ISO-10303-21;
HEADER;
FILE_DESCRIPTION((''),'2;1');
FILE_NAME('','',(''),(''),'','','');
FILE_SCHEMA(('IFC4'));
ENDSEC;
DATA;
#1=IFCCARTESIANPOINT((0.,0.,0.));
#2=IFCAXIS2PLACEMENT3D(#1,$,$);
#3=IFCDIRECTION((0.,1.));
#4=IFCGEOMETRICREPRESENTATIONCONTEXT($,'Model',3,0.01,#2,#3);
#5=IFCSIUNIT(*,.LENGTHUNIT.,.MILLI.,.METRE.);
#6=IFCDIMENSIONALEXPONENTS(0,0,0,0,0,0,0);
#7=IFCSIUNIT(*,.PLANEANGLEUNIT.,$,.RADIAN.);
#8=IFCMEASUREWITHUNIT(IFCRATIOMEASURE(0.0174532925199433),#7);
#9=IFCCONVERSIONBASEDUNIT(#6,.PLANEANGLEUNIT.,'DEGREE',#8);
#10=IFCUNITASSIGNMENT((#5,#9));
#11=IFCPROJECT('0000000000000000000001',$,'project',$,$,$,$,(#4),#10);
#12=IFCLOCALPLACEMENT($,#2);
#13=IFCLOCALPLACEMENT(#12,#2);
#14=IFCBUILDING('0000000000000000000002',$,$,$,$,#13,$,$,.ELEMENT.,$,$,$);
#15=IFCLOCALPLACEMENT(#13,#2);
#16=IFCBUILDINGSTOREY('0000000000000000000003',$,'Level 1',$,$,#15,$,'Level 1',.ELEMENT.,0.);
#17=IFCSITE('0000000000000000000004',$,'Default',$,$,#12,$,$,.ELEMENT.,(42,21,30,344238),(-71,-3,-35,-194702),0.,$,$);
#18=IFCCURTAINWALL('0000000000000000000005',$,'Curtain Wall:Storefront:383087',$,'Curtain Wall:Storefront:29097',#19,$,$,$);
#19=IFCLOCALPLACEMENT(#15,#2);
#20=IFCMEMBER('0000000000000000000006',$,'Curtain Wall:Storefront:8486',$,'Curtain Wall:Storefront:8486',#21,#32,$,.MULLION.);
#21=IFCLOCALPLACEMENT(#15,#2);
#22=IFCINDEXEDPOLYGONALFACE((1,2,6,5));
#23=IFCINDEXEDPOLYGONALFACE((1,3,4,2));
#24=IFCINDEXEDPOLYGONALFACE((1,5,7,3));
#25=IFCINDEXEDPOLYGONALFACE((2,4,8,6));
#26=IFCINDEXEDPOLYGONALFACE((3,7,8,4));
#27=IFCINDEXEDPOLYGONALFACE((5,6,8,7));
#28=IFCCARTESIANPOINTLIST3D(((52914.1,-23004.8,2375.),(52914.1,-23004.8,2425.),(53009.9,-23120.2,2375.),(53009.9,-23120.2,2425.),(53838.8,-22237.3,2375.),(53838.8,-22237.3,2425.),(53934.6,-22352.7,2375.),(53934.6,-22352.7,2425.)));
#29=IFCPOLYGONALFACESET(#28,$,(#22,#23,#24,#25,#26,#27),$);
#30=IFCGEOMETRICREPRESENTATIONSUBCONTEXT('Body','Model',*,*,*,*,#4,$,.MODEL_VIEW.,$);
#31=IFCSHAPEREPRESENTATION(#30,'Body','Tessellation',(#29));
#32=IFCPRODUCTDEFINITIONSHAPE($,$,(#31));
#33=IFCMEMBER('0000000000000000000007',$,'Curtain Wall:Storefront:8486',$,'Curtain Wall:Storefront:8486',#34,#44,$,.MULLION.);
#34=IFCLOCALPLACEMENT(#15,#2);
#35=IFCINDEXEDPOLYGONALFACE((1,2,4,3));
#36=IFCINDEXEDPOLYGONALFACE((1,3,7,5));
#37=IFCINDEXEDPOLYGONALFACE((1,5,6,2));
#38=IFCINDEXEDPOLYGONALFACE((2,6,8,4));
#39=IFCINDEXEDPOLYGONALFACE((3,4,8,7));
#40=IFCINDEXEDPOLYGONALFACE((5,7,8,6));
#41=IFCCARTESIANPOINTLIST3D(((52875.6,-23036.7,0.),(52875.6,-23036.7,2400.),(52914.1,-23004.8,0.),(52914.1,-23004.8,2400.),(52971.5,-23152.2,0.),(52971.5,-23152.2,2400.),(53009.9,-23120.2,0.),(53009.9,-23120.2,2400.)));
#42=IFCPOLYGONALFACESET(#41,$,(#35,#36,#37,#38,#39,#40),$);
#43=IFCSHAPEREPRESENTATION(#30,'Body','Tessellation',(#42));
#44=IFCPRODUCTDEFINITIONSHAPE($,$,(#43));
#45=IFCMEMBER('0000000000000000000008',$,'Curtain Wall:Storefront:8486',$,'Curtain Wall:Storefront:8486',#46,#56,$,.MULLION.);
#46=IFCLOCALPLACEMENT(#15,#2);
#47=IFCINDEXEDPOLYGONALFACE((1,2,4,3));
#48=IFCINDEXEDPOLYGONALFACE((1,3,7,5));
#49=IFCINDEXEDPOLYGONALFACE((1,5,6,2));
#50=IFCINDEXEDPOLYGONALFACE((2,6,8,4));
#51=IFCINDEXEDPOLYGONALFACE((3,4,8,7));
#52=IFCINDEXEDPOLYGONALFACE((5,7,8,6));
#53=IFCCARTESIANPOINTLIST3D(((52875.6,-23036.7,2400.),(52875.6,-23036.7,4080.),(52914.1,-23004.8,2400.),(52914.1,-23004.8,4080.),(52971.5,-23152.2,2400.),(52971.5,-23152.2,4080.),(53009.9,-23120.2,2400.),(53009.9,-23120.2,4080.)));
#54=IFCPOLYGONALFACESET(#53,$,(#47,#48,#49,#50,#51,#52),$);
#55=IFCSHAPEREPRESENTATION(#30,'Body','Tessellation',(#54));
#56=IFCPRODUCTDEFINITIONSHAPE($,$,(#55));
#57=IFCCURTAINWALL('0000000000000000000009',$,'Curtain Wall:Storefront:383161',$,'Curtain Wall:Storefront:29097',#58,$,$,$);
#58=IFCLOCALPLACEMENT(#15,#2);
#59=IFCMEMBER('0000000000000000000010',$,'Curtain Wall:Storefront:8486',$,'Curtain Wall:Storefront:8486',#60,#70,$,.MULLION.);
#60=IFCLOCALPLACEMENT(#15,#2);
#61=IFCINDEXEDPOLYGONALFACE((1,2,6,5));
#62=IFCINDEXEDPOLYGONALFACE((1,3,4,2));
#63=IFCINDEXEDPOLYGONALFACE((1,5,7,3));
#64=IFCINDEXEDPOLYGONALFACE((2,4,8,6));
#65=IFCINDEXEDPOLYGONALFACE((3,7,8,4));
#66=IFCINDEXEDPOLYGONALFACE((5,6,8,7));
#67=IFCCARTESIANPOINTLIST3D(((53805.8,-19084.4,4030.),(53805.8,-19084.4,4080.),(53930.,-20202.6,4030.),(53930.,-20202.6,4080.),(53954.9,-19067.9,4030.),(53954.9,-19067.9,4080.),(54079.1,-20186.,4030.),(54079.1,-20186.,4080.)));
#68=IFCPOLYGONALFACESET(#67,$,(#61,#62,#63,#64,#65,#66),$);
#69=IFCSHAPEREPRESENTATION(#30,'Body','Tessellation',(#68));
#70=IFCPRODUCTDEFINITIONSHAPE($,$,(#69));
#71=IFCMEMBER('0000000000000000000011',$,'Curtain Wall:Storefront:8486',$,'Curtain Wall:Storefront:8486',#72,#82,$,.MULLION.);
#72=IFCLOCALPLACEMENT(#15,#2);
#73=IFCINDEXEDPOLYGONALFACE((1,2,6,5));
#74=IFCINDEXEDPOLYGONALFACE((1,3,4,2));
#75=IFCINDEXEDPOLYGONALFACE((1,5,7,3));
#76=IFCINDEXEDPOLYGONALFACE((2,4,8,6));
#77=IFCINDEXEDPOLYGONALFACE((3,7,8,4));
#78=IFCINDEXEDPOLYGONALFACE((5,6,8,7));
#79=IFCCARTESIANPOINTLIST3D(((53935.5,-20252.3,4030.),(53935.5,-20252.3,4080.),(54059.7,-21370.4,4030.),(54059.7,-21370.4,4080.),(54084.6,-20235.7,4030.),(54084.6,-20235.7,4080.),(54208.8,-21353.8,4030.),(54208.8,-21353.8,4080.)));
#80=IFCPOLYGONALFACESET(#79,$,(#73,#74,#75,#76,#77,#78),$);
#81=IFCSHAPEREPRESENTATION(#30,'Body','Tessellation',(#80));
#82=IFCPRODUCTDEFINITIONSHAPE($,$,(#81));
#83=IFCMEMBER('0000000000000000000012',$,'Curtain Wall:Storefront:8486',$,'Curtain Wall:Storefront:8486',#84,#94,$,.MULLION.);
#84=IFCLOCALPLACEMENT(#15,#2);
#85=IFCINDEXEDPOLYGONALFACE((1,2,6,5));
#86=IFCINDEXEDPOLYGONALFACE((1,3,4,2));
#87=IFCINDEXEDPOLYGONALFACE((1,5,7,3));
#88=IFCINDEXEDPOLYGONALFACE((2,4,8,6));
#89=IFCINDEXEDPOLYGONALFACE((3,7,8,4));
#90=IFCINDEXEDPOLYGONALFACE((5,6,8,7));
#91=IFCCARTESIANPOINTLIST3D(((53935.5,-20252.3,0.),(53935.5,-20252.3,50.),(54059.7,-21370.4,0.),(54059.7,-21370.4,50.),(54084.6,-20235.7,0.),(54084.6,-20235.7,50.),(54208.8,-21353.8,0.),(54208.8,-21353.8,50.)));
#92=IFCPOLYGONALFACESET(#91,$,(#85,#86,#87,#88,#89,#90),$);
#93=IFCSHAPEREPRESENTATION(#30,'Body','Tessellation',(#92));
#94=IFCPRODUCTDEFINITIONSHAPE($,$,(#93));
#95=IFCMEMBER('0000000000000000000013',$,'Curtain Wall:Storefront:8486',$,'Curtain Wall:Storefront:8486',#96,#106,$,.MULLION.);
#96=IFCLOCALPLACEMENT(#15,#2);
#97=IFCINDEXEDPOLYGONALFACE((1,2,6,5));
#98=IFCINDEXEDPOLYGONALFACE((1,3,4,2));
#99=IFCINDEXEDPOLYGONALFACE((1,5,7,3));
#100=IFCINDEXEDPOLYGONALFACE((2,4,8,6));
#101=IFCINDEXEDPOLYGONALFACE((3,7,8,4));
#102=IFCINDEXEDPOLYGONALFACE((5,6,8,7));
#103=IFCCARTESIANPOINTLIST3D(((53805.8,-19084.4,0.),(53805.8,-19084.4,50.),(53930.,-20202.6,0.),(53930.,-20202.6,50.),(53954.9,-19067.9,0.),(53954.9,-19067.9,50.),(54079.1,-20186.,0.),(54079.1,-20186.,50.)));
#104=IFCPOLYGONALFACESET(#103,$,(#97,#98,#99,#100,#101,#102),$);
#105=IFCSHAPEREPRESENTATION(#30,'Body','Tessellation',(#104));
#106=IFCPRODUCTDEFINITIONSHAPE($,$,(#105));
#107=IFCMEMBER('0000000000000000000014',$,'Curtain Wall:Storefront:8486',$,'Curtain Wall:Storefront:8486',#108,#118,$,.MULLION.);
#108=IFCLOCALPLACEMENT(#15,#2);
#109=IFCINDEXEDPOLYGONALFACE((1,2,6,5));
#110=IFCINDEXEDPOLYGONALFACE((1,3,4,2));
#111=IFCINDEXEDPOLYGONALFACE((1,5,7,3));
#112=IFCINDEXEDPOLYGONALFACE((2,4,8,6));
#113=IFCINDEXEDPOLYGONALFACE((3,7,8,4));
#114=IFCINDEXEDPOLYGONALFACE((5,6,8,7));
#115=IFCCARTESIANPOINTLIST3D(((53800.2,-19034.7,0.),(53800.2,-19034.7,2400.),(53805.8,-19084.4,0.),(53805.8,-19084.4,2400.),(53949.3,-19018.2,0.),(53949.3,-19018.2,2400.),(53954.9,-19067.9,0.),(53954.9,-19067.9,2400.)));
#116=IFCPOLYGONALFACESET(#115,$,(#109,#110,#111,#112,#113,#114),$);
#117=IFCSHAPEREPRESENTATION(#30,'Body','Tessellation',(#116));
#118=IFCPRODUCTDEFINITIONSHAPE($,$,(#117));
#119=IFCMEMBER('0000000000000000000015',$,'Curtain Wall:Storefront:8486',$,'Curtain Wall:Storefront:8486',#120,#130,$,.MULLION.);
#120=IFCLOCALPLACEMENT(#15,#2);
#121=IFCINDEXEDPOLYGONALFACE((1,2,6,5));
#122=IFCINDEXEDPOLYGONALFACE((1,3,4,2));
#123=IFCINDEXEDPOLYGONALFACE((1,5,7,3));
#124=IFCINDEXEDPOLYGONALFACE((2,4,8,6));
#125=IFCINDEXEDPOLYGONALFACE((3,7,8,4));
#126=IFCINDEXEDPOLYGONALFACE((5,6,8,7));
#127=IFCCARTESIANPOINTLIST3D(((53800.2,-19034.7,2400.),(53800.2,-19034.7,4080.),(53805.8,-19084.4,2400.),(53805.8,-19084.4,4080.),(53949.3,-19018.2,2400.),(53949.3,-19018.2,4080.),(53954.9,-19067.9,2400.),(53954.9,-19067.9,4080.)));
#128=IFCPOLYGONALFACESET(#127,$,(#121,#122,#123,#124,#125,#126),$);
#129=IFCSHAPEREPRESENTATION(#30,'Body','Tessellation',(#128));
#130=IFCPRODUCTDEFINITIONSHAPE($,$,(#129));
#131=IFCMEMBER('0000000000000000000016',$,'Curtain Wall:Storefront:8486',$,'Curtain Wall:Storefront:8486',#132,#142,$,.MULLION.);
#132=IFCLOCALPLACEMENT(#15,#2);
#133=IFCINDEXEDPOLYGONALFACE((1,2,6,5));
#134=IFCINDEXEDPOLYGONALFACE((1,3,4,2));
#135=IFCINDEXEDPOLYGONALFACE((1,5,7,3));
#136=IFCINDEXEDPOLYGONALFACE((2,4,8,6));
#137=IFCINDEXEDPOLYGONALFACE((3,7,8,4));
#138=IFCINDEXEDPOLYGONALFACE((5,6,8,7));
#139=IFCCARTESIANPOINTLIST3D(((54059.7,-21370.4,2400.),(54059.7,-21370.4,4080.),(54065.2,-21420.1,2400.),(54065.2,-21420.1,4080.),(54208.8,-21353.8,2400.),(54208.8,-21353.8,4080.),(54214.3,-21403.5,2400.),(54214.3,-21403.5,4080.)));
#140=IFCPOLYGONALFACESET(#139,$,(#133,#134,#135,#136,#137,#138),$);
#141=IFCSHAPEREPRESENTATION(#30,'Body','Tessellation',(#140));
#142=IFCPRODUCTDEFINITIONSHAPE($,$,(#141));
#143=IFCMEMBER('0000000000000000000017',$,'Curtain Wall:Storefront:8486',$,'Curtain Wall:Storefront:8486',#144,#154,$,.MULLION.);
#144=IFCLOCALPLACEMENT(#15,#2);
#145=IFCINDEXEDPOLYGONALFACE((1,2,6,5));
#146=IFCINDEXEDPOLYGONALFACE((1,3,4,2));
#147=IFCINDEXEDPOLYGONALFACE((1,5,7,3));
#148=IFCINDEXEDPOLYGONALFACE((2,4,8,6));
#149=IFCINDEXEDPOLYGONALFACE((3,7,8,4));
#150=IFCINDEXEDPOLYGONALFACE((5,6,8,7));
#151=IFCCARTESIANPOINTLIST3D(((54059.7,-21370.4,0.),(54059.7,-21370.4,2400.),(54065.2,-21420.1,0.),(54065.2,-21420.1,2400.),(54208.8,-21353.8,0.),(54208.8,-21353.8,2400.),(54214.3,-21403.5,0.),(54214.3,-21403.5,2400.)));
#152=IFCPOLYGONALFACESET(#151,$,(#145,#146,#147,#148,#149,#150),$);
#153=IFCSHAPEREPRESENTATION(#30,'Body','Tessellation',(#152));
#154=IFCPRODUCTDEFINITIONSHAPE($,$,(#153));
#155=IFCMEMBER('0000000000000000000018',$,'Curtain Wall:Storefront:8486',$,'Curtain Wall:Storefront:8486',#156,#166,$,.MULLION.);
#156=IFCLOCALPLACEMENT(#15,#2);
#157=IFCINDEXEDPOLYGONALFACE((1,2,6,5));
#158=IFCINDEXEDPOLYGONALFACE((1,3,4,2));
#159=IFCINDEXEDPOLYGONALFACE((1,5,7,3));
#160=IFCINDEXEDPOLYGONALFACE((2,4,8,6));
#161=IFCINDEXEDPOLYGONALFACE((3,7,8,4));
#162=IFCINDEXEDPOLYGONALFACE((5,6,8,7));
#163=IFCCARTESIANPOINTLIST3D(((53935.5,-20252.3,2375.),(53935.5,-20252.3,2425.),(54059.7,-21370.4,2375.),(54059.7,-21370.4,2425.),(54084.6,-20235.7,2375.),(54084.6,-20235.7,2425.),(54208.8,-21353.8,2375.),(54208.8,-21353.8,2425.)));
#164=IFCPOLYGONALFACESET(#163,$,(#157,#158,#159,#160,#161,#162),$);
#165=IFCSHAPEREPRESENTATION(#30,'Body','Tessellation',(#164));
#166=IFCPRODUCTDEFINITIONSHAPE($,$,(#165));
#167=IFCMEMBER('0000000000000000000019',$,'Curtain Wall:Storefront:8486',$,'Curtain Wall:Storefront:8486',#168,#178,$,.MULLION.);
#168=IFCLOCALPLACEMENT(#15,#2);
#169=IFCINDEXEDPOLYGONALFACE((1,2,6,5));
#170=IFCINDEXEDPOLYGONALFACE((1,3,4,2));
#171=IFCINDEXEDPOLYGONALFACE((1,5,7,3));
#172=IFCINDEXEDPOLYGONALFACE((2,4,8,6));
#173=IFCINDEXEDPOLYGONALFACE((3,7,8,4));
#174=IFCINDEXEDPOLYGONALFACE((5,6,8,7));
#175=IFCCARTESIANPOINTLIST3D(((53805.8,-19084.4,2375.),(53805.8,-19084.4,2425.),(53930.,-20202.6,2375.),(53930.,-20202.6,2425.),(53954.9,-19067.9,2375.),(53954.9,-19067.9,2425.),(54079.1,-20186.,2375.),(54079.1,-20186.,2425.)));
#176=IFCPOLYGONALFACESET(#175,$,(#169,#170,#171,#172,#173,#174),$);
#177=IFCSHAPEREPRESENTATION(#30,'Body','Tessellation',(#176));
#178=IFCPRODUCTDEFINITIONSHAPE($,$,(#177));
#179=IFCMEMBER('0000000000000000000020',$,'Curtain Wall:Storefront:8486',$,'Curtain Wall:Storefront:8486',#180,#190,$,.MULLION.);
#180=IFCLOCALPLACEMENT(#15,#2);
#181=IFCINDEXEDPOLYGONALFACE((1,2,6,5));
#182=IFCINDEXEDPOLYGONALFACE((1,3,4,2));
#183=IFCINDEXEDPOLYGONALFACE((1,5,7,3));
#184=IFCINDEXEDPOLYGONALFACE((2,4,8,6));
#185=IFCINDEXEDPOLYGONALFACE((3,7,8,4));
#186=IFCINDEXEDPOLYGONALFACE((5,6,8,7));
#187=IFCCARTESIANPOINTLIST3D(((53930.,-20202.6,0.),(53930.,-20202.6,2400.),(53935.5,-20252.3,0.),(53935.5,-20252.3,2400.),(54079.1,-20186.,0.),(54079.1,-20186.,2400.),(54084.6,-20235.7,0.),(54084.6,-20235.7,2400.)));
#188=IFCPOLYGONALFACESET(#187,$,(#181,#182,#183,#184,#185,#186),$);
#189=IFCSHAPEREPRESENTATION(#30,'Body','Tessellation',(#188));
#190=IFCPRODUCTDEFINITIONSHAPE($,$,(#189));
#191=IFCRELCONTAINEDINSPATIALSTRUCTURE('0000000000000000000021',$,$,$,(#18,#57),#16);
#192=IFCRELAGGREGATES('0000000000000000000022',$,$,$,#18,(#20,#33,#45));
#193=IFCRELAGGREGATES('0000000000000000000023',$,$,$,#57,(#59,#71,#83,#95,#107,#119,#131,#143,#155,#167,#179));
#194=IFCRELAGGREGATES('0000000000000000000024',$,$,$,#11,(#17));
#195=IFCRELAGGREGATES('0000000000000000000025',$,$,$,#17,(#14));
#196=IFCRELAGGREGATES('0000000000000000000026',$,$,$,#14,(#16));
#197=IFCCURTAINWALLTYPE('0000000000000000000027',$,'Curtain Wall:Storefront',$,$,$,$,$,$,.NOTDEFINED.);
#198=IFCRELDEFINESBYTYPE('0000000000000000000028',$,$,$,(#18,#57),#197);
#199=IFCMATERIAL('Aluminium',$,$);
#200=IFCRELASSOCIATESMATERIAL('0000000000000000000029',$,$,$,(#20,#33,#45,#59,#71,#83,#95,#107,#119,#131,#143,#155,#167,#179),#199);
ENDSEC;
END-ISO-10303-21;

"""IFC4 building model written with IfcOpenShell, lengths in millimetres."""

from ifc_helpers import new_model, entity, si_unit, converted_unit, direction, frame, frame_2d, origin, origin_2d_with_axis, place, context, subcontext, project, spatial, rectangle, extrude, material, type_object, element, aggregate, save


model = new_model("IFC4")

# Units and contexts
model_context = context("Model", 3, precision=0.01, world=origin(), true_north=direction((0.0, 1.0)))
body_context = subcontext(model_context, "Body", "Model", "MODEL_VIEW")
ifc_project = project(units=[si_unit("LENGTHUNIT", "METRE", prefix="MILLI"), converted_unit("PLANEANGLEUNIT", "DEGREE", entity("IfcRatioMeasure", 0.0174532925199433), si_unit("PLANEANGLEUNIT", "RADIAN"), dimensions=[0, 0, 0, 0, 0, 0, 0])], contexts=[model_context])

# Site, building, storey
site_placement = place(None, origin())
site = spatial("IfcSite", under=ifc_project, at=site_placement, Name="Default", CompositionType="ELEMENT", RefLatitude=(42, 21, 30, 344238), RefLongitude=(-71, -3, -35, -194702), RefElevation=0.0)
building_placement = place(site_placement, origin())
building = spatial("IfcBuilding", under=site, at=building_placement, CompositionType="ELEMENT")
storey_placement = place(building_placement, origin())
storey = spatial("IfcBuildingStorey", under=building, at=storey_placement, Name="Level 1", LongName="Level 1", CompositionType="ELEMENT", Elevation=0.0)

# Curtain walls, members
curtain_wall_type = type_object("IfcCurtainWallType", Name="Curtain Wall:Storefront", PredefinedType="NOTDEFINED")
curtain_wall_1_placement = place(storey_placement, origin())
curtain_wall_1 = element("IfcCurtainWall", 1, at=curtain_wall_1_placement, inside=storey, type_object=curtain_wall_type, Name="Curtain Wall:Storefront:383087", ObjectType="Curtain Wall:Storefront:29097")
ifc_material = material(Name="Aluminium")
member_1_placement = place(curtain_wall_1_placement, origin())
member_1 = element("IfcMember", 2, at=member_1_placement, material=ifc_material, Name="Curtain Wall:Storefront:8486", ObjectType="Curtain Wall:Storefront:8486", PredefinedType="MULLION", context=body_context, shape_type="SweptSolid", body=[
    extrude(rectangle(XDim=50.0, YDim=150.0, at=origin_2d_with_axis()), frame((53886.7, -22295.0, 2400.0), z_axis=(-0.769477, -0.638675, 0.0), x_axis=(0.0, 0.0, -1.0)), (0.0, 0.0, 1.0), 1201.7),
])
member_2_placement = place(curtain_wall_1_placement, origin())
member_2 = element("IfcMember", 3, at=member_2_placement, material=ifc_material, Name="Curtain Wall:Storefront:8486", ObjectType="Curtain Wall:Storefront:8486", PredefinedType="MULLION", context=body_context, shape_type="SweptSolid", body=[
    extrude(rectangle(XDim=50.0, YDim=150.0, at=origin_2d_with_axis()), frame((52942.8, -23078.5, 0.0), z_axis=(0.0, 0.0, 1.0), x_axis=(0.769477, 0.638675, 0.0)), (0.0, 0.0, 1.0), 2400.0),
])
member_3_placement = place(curtain_wall_1_placement, origin())
member_3 = element("IfcMember", 4, at=member_3_placement, material=ifc_material, Name="Curtain Wall:Storefront:8486", ObjectType="Curtain Wall:Storefront:8486", PredefinedType="MULLION", context=body_context, shape_type="SweptSolid", body=[
    extrude(rectangle(XDim=50.0, YDim=150.0, at=origin_2d_with_axis()), frame((52942.8, -23078.5, 2400.0), z_axis=(0.0, 0.0, 1.0), x_axis=(0.769477, 0.638675, 0.0)), (0.0, 0.0, 1.0), 1680.0),
])
aggregate(curtain_wall_1, [member_1, member_2, member_3])
curtain_wall_2_placement = place(storey_placement, origin())
curtain_wall_2 = element("IfcCurtainWall", 5, at=curtain_wall_2_placement, inside=storey, type_object=curtain_wall_type, Name="Curtain Wall:Storefront:383161", ObjectType="Curtain Wall:Storefront:29097")
member_4_placement = place(curtain_wall_2_placement, origin())
member_4 = element("IfcMember", 6, at=member_4_placement, material=ifc_material, Name="Curtain Wall:Storefront:8486", ObjectType="Curtain Wall:Storefront:8486", PredefinedType="MULLION", context=body_context, shape_type="SweptSolid", body=[
    extrude(rectangle(XDim=50.0, YDim=150.0, at=frame_2d((0.0, 0.0), x_axis=(1.0, 0.0))), frame((53880.3, -19076.2, 4055.0), z_axis=(0.110402, -0.993887, 0.0), x_axis=(0.0, 0.0, -1.0)), (0.0, 0.0, 1.0), 1125.0),
])
member_5_placement = place(curtain_wall_2_placement, origin())
member_5 = element("IfcMember", 7, at=member_5_placement, material=ifc_material, Name="Curtain Wall:Storefront:8486", ObjectType="Curtain Wall:Storefront:8486", PredefinedType="MULLION", context=body_context, shape_type="SweptSolid", body=[
    extrude(rectangle(XDim=50.0, YDim=150.0, at=frame_2d((0.0, 0.0), x_axis=(1.0, 0.0))), frame((54010.0, -20244.0, 4055.0), z_axis=(0.110402, -0.993887, 0.0), x_axis=(0.0, 0.0, -1.0)), (0.0, 0.0, 1.0), 1125.0),
])
member_6_placement = place(curtain_wall_2_placement, origin())
member_6 = element("IfcMember", 8, at=member_6_placement, material=ifc_material, Name="Curtain Wall:Storefront:8486", ObjectType="Curtain Wall:Storefront:8486", PredefinedType="MULLION", context=body_context, shape_type="SweptSolid", body=[
    extrude(rectangle(XDim=50.0, YDim=150.0, at=frame_2d((0.0, 0.0), x_axis=(1.0, 0.0))), frame((54134.2, -21362.1, 25.0), z_axis=(-0.110402, 0.993887, 0.0), x_axis=(0.0, 0.0, -1.0)), (0.0, 0.0, 1.0), 1125.0),
])
member_7_placement = place(curtain_wall_2_placement, origin())
member_7 = element("IfcMember", 9, at=member_7_placement, material=ifc_material, Name="Curtain Wall:Storefront:8486", ObjectType="Curtain Wall:Storefront:8486", PredefinedType="MULLION", context=body_context, shape_type="SweptSolid", body=[
    extrude(rectangle(XDim=50.0, YDim=150.0, at=frame_2d((0.0, 0.0), x_axis=(1.0, 0.0))), frame((54004.5, -20194.3, 25.0), z_axis=(-0.110402, 0.993887, 0.0), x_axis=(0.0, 0.0, -1.0)), (0.0, 0.0, 1.0), 1125.0),
])
member_8_placement = place(curtain_wall_2_placement, origin())
member_8 = element("IfcMember", 10, at=member_8_placement, material=ifc_material, Name="Curtain Wall:Storefront:8486", ObjectType="Curtain Wall:Storefront:8486", PredefinedType="MULLION", context=body_context, shape_type="SweptSolid", body=[
    extrude(rectangle(XDim=50.0, YDim=150.0, at=frame_2d((0.0, 0.0), x_axis=(1.0, 0.0))), frame((53877.6, -19051.3, 0.0), z_axis=(0.0, 0.0, 1.0), x_axis=(-0.110402, 0.993887, 0.0)), (0.0, 0.0, 1.0), 2400.0),
])
member_9_placement = place(curtain_wall_2_placement, origin())
member_9 = element("IfcMember", 11, at=member_9_placement, material=ifc_material, Name="Curtain Wall:Storefront:8486", ObjectType="Curtain Wall:Storefront:8486", PredefinedType="MULLION", context=body_context, shape_type="SweptSolid", body=[
    extrude(rectangle(XDim=50.0, YDim=150.0, at=frame_2d((0.0, 0.0), x_axis=(1.0, 0.0))), frame((53877.6, -19051.3, 2400.0), z_axis=(0.0, 0.0, 1.0), x_axis=(-0.110402, 0.993887, 0.0)), (0.0, 0.0, 1.0), 1680.0),
])
member_10_placement = place(curtain_wall_2_placement, origin())
member_10 = element("IfcMember", 12, at=member_10_placement, material=ifc_material, Name="Curtain Wall:Storefront:8486", ObjectType="Curtain Wall:Storefront:8486", PredefinedType="MULLION", context=body_context, shape_type="SweptSolid", body=[
    extrude(rectangle(XDim=50.0, YDim=150.0, at=frame_2d((0.0, 0.0), x_axis=(1.0, 0.0))), frame((54137.0, -21386.9, 4080.0), z_axis=(0.0, 0.0, -1.0), x_axis=(0.110402, -0.993887, 0.0)), (0.0, 0.0, 1.0), 1680.0),
])
member_11_placement = place(curtain_wall_2_placement, origin())
member_11 = element("IfcMember", 13, at=member_11_placement, material=ifc_material, Name="Curtain Wall:Storefront:8486", ObjectType="Curtain Wall:Storefront:8486", PredefinedType="MULLION", context=body_context, shape_type="SweptSolid", body=[
    extrude(rectangle(XDim=50.0, YDim=150.0, at=frame_2d((0.0, 0.0), x_axis=(1.0, 0.0))), frame((54137.0, -21386.9, 2400.0), z_axis=(0.0, 0.0, -1.0), x_axis=(0.110402, -0.993887, 0.0)), (0.0, 0.0, 1.0), 2400.0),
])
member_12_placement = place(curtain_wall_2_placement, origin())
member_12 = element("IfcMember", 14, at=member_12_placement, material=ifc_material, Name="Curtain Wall:Storefront:8486", ObjectType="Curtain Wall:Storefront:8486", PredefinedType="MULLION", context=body_context, shape_type="SweptSolid", body=[
    extrude(rectangle(XDim=50.0, YDim=150.0, at=origin_2d_with_axis()), frame((54010.0, -20244.0, 2400.0), z_axis=(0.110402, -0.993887, 0.0), x_axis=(0.0, 0.0, -1.0)), (0.0, 0.0, 1.0), 1125.0),
])
member_13_placement = place(curtain_wall_2_placement, origin())
member_13 = element("IfcMember", 15, at=member_13_placement, material=ifc_material, Name="Curtain Wall:Storefront:8486", ObjectType="Curtain Wall:Storefront:8486", PredefinedType="MULLION", context=body_context, shape_type="SweptSolid", body=[
    extrude(rectangle(XDim=50.0, YDim=150.0, at=origin_2d_with_axis()), frame((53880.3, -19076.2, 2400.0), z_axis=(0.110402, -0.993887, 0.0), x_axis=(0.0, 0.0, -1.0)), (0.0, 0.0, 1.0), 1125.0),
])
member_14_placement = place(curtain_wall_2_placement, origin())
member_14 = element("IfcMember", 16, at=member_14_placement, material=ifc_material, Name="Curtain Wall:Storefront:8486", ObjectType="Curtain Wall:Storefront:8486", PredefinedType="MULLION", context=body_context, shape_type="SweptSolid", body=[
    extrude(rectangle(XDim=50.0, YDim=150.0, at=origin_2d_with_axis()), frame((54007.3, -20219.1, 0.0), z_axis=(0.0, 0.0, 1.0), x_axis=(-0.110402, 0.993887, 0.0)), (0.0, 0.0, 1.0), 2400.0),
])
aggregate(curtain_wall_2, [member_4, member_5, member_6, member_7, member_8, member_9, member_10, member_11, member_12, member_13, member_14])

save(model, "model.ifc")
